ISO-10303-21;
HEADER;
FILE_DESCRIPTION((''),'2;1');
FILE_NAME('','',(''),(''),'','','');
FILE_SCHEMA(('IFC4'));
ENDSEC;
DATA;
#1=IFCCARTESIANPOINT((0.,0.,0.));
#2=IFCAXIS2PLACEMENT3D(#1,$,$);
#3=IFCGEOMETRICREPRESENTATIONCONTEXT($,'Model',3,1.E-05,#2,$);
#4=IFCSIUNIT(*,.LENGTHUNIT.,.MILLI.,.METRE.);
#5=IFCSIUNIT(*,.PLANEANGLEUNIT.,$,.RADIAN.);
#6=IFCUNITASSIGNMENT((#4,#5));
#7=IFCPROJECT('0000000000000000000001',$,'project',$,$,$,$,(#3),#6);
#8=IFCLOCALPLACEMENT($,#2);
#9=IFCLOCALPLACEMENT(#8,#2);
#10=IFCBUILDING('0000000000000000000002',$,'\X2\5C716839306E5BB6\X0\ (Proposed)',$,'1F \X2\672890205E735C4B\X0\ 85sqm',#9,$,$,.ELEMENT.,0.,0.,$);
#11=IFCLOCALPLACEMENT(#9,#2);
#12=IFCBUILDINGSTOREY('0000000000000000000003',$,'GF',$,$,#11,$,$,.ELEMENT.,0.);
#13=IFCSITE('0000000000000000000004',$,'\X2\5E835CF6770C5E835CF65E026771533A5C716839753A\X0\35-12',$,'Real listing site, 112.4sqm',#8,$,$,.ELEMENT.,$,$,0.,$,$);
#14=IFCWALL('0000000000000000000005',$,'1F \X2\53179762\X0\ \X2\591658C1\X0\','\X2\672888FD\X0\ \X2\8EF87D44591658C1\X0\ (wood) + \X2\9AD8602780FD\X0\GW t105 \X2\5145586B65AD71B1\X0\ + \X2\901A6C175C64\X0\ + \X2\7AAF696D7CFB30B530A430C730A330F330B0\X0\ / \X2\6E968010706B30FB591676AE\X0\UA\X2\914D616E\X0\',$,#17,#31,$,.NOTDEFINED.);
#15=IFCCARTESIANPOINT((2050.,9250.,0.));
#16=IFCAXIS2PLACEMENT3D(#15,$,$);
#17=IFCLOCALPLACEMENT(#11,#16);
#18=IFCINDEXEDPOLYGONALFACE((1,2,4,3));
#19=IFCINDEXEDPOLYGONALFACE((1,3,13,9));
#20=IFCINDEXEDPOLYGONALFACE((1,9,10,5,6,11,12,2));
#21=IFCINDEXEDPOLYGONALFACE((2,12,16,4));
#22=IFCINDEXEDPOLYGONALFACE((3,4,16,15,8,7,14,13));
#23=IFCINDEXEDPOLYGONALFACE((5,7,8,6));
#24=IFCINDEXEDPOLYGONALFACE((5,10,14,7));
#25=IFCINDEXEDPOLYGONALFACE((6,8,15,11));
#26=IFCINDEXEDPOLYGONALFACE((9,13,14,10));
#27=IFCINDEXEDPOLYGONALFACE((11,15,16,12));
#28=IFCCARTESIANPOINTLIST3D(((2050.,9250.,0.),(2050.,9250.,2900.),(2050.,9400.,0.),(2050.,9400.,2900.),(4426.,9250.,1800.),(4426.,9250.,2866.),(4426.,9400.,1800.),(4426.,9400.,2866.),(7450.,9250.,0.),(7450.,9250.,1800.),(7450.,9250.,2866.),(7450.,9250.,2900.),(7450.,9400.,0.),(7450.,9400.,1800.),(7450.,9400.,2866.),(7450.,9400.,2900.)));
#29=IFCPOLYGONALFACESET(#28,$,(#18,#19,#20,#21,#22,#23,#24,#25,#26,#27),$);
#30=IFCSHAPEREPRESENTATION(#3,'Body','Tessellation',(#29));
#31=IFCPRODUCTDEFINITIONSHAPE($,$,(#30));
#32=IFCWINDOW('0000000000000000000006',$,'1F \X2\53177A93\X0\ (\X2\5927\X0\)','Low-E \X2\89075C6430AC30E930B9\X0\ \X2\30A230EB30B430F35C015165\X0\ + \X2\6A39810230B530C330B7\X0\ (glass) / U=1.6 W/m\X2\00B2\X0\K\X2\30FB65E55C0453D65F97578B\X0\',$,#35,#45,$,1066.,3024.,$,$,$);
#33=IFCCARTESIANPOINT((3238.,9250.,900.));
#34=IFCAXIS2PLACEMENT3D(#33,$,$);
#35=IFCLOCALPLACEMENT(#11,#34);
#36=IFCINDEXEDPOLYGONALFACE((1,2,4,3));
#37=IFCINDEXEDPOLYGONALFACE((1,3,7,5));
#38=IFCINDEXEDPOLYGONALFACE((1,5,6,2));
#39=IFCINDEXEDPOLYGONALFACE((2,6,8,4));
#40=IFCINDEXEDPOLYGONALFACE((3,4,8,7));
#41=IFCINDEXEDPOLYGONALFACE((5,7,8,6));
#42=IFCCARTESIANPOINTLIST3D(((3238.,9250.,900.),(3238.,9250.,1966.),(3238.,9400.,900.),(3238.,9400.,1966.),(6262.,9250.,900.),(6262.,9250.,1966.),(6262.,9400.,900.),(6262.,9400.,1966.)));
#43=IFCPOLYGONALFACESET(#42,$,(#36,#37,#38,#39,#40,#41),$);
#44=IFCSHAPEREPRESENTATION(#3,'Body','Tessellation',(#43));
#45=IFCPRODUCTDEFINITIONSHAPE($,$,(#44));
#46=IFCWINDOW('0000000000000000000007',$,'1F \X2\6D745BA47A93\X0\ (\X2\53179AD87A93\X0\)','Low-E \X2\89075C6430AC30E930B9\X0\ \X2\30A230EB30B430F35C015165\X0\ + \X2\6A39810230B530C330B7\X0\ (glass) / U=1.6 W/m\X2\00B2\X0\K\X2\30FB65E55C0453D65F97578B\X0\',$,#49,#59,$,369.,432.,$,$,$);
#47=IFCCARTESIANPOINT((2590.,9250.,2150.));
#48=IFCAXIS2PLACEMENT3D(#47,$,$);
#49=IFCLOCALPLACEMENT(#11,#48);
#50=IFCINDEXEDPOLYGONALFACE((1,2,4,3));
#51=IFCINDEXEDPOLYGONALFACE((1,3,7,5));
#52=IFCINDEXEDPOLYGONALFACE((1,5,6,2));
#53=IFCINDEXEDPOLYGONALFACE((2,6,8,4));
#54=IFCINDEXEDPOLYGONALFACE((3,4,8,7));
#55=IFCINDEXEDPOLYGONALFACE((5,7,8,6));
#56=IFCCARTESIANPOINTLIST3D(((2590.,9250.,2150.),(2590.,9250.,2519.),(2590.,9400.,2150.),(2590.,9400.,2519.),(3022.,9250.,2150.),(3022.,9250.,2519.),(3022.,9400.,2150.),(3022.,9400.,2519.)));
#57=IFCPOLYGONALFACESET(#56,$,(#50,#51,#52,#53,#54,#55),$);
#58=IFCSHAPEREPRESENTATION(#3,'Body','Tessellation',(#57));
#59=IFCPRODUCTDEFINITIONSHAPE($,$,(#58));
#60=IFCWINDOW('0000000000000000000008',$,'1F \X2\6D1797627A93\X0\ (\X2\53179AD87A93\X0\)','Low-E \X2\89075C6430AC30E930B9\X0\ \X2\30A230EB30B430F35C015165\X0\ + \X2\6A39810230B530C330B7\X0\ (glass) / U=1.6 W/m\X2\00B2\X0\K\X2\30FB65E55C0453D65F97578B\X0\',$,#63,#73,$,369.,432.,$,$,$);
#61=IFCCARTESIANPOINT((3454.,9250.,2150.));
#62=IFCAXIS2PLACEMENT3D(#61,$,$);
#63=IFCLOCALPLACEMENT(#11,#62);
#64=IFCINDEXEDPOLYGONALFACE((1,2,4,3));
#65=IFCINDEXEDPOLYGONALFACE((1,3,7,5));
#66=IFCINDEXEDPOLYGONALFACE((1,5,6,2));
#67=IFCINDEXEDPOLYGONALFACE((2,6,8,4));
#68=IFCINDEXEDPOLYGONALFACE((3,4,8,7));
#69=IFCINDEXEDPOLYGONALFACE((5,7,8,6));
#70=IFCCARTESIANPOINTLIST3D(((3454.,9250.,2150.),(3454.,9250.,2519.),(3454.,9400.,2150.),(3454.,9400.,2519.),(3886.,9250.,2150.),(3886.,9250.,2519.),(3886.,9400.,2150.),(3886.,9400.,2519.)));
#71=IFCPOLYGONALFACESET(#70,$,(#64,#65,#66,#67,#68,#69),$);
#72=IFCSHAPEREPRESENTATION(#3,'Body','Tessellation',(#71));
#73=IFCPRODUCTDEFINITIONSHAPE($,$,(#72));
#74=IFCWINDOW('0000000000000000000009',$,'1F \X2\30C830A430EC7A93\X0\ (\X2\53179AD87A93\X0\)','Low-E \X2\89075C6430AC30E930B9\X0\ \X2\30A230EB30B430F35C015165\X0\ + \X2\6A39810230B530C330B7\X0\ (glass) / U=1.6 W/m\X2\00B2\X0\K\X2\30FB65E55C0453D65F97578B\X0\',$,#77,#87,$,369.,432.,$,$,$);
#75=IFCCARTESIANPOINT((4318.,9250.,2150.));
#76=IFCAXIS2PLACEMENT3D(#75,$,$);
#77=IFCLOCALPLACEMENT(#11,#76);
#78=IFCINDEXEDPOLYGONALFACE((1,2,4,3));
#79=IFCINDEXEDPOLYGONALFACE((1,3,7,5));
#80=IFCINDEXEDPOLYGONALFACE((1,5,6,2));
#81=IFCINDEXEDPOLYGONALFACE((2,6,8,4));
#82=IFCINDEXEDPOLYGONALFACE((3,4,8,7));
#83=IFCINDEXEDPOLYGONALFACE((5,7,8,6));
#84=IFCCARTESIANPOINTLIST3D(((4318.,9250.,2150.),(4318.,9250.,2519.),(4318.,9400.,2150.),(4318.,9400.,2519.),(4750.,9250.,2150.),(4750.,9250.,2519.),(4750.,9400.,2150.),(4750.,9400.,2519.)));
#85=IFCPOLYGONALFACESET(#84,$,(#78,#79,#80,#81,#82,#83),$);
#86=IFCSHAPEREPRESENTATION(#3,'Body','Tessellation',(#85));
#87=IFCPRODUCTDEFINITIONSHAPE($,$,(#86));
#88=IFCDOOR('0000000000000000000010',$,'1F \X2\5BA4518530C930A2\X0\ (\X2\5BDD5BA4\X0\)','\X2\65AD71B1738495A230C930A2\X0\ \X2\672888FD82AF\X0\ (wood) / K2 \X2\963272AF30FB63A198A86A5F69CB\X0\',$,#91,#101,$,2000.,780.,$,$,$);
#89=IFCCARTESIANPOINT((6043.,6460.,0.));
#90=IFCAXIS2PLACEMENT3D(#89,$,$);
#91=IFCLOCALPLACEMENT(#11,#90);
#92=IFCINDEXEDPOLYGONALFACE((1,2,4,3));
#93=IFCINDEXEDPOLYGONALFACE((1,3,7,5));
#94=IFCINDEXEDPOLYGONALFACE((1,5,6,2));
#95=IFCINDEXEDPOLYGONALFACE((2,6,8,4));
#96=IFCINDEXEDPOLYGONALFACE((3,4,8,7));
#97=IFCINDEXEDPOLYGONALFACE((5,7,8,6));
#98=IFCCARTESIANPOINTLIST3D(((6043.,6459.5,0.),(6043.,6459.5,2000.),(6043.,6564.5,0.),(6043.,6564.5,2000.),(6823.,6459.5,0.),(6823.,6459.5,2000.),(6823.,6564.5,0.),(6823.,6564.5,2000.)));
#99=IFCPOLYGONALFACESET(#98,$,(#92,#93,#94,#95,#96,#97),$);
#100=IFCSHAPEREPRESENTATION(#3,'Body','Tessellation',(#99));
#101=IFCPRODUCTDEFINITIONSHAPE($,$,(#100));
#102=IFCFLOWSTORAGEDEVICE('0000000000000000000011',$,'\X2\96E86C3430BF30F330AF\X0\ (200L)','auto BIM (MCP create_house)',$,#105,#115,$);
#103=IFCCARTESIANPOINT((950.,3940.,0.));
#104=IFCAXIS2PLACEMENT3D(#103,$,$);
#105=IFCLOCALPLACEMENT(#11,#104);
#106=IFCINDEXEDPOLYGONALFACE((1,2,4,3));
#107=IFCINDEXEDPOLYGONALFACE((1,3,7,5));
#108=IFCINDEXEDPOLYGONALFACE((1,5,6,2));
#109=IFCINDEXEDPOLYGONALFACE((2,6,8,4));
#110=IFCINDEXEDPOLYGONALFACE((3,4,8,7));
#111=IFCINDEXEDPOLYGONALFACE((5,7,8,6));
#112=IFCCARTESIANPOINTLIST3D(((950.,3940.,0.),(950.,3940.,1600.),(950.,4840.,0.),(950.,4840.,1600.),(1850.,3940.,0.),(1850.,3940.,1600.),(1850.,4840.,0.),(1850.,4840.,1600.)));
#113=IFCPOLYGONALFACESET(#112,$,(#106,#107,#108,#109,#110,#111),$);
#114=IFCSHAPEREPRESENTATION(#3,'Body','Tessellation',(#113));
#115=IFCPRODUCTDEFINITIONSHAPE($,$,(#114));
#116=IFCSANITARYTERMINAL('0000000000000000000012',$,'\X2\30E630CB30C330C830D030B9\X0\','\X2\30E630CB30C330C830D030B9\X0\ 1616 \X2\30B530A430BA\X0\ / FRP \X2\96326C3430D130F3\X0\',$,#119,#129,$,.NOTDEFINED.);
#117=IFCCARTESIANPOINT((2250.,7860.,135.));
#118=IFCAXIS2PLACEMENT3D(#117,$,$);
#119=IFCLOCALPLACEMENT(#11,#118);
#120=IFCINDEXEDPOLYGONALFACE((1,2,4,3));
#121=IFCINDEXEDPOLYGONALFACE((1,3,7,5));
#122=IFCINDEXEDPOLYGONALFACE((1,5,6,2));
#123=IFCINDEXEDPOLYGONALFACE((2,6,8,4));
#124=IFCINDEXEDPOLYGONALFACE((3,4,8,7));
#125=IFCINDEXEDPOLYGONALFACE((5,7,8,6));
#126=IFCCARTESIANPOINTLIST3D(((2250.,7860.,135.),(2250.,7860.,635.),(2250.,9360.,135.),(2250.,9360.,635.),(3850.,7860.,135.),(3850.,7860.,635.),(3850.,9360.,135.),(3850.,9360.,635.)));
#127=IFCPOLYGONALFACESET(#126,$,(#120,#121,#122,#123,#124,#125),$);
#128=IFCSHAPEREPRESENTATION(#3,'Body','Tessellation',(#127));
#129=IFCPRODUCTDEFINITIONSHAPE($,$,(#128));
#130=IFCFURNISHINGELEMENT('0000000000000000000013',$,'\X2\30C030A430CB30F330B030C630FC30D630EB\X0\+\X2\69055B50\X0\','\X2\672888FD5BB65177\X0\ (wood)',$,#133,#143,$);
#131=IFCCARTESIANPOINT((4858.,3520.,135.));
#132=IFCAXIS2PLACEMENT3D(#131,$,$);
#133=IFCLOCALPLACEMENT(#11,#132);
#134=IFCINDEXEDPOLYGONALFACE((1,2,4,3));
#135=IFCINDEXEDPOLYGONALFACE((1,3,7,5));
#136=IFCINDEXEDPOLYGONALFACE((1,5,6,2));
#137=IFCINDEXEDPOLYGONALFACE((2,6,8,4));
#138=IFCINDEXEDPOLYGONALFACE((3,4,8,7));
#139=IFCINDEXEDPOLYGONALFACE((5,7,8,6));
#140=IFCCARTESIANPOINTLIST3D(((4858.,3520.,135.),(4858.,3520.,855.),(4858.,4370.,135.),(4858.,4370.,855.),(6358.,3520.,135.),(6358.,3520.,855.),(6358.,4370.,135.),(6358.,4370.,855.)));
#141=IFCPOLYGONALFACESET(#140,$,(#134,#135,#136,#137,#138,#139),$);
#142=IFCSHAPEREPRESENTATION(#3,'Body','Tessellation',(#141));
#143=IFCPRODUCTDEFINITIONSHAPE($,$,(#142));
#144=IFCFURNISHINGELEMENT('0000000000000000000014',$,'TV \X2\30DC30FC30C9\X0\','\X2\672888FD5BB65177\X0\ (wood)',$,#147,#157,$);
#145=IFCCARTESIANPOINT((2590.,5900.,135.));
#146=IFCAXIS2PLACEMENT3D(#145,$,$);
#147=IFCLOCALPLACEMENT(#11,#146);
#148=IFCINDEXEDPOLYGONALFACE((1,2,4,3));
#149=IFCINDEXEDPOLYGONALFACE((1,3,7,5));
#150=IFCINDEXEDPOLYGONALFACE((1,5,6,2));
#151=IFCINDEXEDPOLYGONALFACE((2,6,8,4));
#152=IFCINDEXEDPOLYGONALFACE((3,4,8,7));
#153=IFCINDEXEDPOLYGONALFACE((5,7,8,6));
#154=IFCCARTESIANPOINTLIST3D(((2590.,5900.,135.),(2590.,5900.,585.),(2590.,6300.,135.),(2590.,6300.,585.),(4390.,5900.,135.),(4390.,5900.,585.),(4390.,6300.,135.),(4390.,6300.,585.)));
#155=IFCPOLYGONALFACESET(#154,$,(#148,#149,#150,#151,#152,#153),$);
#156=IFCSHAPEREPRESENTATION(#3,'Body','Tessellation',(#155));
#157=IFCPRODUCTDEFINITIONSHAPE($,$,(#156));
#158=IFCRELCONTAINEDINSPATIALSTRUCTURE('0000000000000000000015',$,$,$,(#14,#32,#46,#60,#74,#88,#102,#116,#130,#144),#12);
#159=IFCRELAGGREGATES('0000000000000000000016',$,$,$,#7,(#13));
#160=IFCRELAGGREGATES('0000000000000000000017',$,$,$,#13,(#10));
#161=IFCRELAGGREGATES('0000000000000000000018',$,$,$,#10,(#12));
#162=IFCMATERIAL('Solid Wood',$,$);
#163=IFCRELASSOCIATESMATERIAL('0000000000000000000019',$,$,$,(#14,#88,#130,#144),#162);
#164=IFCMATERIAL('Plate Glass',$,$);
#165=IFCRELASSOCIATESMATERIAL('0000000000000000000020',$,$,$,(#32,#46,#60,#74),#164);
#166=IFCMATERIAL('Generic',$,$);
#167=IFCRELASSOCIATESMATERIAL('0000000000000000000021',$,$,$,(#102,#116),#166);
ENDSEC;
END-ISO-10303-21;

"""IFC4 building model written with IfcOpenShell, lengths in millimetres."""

from ifc_helpers import new_model, si_unit, frame, frame_2d, origin, place, context, project, spatial, rectangle, extrude, material, element, fill, save


model = new_model("IFC4")

# Units and contexts
model_context = context("Model", 3, precision=1e-05, world=origin())
ifc_project = project(units=[si_unit("LENGTHUNIT", "METRE", prefix="MILLI"), si_unit("PLANEANGLEUNIT", "RADIAN")], contexts=[model_context])

# Site, building, storey
site_placement = place(None, origin())
site = spatial("IfcSite", under=ifc_project, at=site_placement, Name="広島県広島市東区山根町35-12", ObjectType="Real listing site, 112.4sqm", CompositionType="ELEMENT", RefElevation=0.0)
building_placement = place(site_placement, origin())
building = spatial("IfcBuilding", under=site, at=building_placement, Name="山根の家 (Proposed)", ObjectType="1F 木造平屋 85sqm", CompositionType="ELEMENT", ElevationOfRefHeight=0.0, ElevationOfTerrain=0.0)
storey_placement = place(building_placement, origin())
storey = spatial("IfcBuildingStorey", under=building, at=storey_placement, Name="GF", CompositionType="ELEMENT", Elevation=0.0)

# Wall, openings, windows
ifc_material_1 = material(Name="Solid Wood")
wall_1_placement = place(storey_placement, frame((2050.0, 9250.0, 0.0)))
wall_1 = element("IfcWall", 1, at=wall_1_placement, inside=storey, material=ifc_material_1, Name="1F 北面 外壁", Description="木製 軸組外壁 (wood) + 高性能GW t105 充填断熱 + 通気層 + 窯業系サイディング / 準耐火・外皮UA配慮", PredefinedType="NOTDEFINED", context=model_context, shape_type="SweptSolid", body=[
    extrude(rectangle(XDim=5400.0, YDim=150.0, at=frame_2d((2700.0, 75.0))), frame((2050.0, 9250.0, 0.0)), (0.0, 0.0, 1.0), 2900.0),
])
opening_1_placement = place(storey_placement, frame((3238.0, 9250.0, 900.0)))
opening_1 = element("IfcOpeningElement", 2, at=opening_1_placement, cuts=wall_1, PredefinedType="NOTDEFINED", context=model_context, shape_type="SweptSolid", body=[
    extrude(rectangle(XDim=3024.0, YDim=150.0, at=frame_2d((1512.0, 75.0))), frame((3238.0, 9250.0, 900.0)), (0.0, 0.0, 1.0), 1066.0),
])
opening_2_placement = place(storey_placement, frame((2590.0, 9250.0, 2150.0)))
opening_2 = element("IfcOpeningElement", 3, at=opening_2_placement, cuts=wall_1, PredefinedType="NOTDEFINED", context=model_context, shape_type="SweptSolid", body=[
    extrude(rectangle(XDim=432.0, YDim=150.0, at=frame_2d((216.0, 75.0))), frame((2590.0, 9250.0, 2150.0)), (0.0, 0.0, 1.0), 369.0),
])
opening_3_placement = place(storey_placement, frame((3454.0, 9250.0, 2150.0)))
opening_3 = element("IfcOpeningElement", 4, at=opening_3_placement, cuts=wall_1, PredefinedType="NOTDEFINED", context=model_context, shape_type="SweptSolid", body=[
    extrude(rectangle(XDim=432.0, YDim=150.0, at=frame_2d((216.0, 75.0))), frame((3454.0, 9250.0, 2150.0)), (0.0, 0.0, 1.0), 369.0),
])
opening_4_placement = place(storey_placement, frame((4318.0, 9250.0, 2150.0)))
opening_4 = element("IfcOpeningElement", 5, at=opening_4_placement, cuts=wall_1, PredefinedType="NOTDEFINED", context=model_context, shape_type="SweptSolid", body=[
    extrude(rectangle(XDim=432.0, YDim=150.0, at=frame_2d((216.0, 75.0))), frame((4318.0, 9250.0, 2150.0)), (0.0, 0.0, 1.0), 369.0),
])
ifc_material_2 = material(Name="Plate Glass")
window_1_placement = place(storey_placement, frame((3238.0, 9250.0, 900.0)))
window_1 = element("IfcWindow", 6, at=window_1_placement, inside=storey, material=ifc_material_2, Name="1F 北窓 (大)", Description="Low-E 複層ガラス アルゴン封入 + 樹脂サッシ (glass) / U=1.6 W/m²K・日射取得型", OverallHeight=1066.0, OverallWidth=3024.0, context=model_context, shape_type="SweptSolid", body=[
    extrude(rectangle(XDim=3024.0, YDim=150.0, at=frame_2d((1512.0, 75.0))), frame((3238.0, 9250.0, 900.0)), (0.0, 0.0, 1.0), 1066.0),
])
fill(opening_1, window_1)
window_2_placement = place(storey_placement, frame((2590.0, 9250.0, 2150.0)))
window_2 = element("IfcWindow", 7, at=window_2_placement, inside=storey, material=ifc_material_2, Name="1F 浴室窓 (北高窓)", Description="Low-E 複層ガラス アルゴン封入 + 樹脂サッシ (glass) / U=1.6 W/m²K・日射取得型", OverallHeight=369.0, OverallWidth=432.0, context=model_context, shape_type="SweptSolid", body=[
    extrude(rectangle(XDim=432.0, YDim=150.0, at=frame_2d((216.0, 75.0))), frame((2590.0, 9250.0, 2150.0)), (0.0, 0.0, 1.0), 369.0),
])
fill(opening_2, window_2)
window_3_placement = place(storey_placement, frame((3454.0, 9250.0, 2150.0)))
window_3 = element("IfcWindow", 8, at=window_3_placement, inside=storey, material=ifc_material_2, Name="1F 洗面窓 (北高窓)", Description="Low-E 複層ガラス アルゴン封入 + 樹脂サッシ (glass) / U=1.6 W/m²K・日射取得型", OverallHeight=369.0, OverallWidth=432.0, context=model_context, shape_type="SweptSolid", body=[
    extrude(rectangle(XDim=432.0, YDim=150.0, at=frame_2d((216.0, 75.0))), frame((3454.0, 9250.0, 2150.0)), (0.0, 0.0, 1.0), 369.0),
])
fill(opening_3, window_3)
window_4_placement = place(storey_placement, frame((4318.0, 9250.0, 2150.0)))
window_4 = element("IfcWindow", 9, at=window_4_placement, inside=storey, material=ifc_material_2, Name="1F トイレ窓 (北高窓)", Description="Low-E 複層ガラス アルゴン封入 + 樹脂サッシ (glass) / U=1.6 W/m²K・日射取得型", OverallHeight=369.0, OverallWidth=432.0, context=model_context, shape_type="SweptSolid", body=[
    extrude(rectangle(XDim=432.0, YDim=150.0, at=frame_2d((216.0, 75.0))), frame((4318.0, 9250.0, 2150.0)), (0.0, 0.0, 1.0), 369.0),
])
fill(opening_4, window_4)

# Door
door_1_placement = place(storey_placement, frame((6043.0, 6460.0, 0.0)))
element("IfcDoor", 10, at=door_1_placement, inside=storey, material=ifc_material_1, Name="1F 室内ドア (寝室)", Description="断熱玄関ドア 木製芯 (wood) / K2 防犯・採風機構", OverallHeight=2000.0, OverallWidth=780.0, context=model_context, shape_type="SweptSolid", body=[
    extrude(rectangle(XDim=780.0, YDim=105.0, at=frame_2d((390.0, 52.0))), frame((6043.0, 6460.0, 0.0)), (0.0, 0.0, 1.0), 2000.0),
])

# Flow storage device
ifc_material_3 = material(Name="Generic")
flow_storage_device_placement = place(storey_placement, frame((950.0, 3940.0, 0.0)))
element("IfcFlowStorageDevice", 11, at=flow_storage_device_placement, inside=storey, material=ifc_material_3, Name="雨水タンク (200L)", Description="auto BIM (MCP create_house)", context=model_context, shape_type="SweptSolid", body=[
    extrude(rectangle(XDim=900.0, YDim=900.0, at=frame_2d((450.0, 450.0))), frame((950.0, 3940.0, 0.0)), (0.0, 0.0, 1.0), 1600.0),
])

# Sanitary terminal
sanitary_terminal_placement = place(storey_placement, frame((2250.0, 7860.0, 135.0)))
element("IfcSanitaryTerminal", 12, at=sanitary_terminal_placement, inside=storey, material=ifc_material_3, Name="ユニットバス", Description="ユニットバス 1616 サイズ / FRP 防水パン", PredefinedType="NOTDEFINED", context=model_context, shape_type="SweptSolid", body=[
    extrude(rectangle(XDim=1600.0, YDim=1500.0, at=frame_2d((800.0, 750.0))), frame((2250.0, 7860.0, 135.0)), (0.0, 0.0, 1.0), 500.0),
])

# Furnishing elements
furnishing_1_placement = place(storey_placement, frame((4858.0, 3520.0, 135.0)))
element("IfcFurnishingElement", 13, at=furnishing_1_placement, inside=storey, material=ifc_material_1, Name="ダイニングテーブル+椅子", Description="木製家具 (wood)", context=model_context, shape_type="SweptSolid", body=[
    extrude(rectangle(XDim=1500.0, YDim=850.0, at=frame_2d((750.0, 425.0))), frame((4858.0, 3520.0, 135.0)), (0.0, 0.0, 1.0), 720.0),
])
furnishing_2_placement = place(storey_placement, frame((2590.0, 5900.0, 135.0)))
element("IfcFurnishingElement", 14, at=furnishing_2_placement, inside=storey, material=ifc_material_1, Name="TV ボード", Description="木製家具 (wood)", context=model_context, shape_type="SweptSolid", body=[
    extrude(rectangle(XDim=1800.0, YDim=400.0, at=frame_2d((900.0, 200.0))), frame((2590.0, 5900.0, 135.0)), (0.0, 0.0, 1.0), 450.0),
])

save(model, "model.ifc")
